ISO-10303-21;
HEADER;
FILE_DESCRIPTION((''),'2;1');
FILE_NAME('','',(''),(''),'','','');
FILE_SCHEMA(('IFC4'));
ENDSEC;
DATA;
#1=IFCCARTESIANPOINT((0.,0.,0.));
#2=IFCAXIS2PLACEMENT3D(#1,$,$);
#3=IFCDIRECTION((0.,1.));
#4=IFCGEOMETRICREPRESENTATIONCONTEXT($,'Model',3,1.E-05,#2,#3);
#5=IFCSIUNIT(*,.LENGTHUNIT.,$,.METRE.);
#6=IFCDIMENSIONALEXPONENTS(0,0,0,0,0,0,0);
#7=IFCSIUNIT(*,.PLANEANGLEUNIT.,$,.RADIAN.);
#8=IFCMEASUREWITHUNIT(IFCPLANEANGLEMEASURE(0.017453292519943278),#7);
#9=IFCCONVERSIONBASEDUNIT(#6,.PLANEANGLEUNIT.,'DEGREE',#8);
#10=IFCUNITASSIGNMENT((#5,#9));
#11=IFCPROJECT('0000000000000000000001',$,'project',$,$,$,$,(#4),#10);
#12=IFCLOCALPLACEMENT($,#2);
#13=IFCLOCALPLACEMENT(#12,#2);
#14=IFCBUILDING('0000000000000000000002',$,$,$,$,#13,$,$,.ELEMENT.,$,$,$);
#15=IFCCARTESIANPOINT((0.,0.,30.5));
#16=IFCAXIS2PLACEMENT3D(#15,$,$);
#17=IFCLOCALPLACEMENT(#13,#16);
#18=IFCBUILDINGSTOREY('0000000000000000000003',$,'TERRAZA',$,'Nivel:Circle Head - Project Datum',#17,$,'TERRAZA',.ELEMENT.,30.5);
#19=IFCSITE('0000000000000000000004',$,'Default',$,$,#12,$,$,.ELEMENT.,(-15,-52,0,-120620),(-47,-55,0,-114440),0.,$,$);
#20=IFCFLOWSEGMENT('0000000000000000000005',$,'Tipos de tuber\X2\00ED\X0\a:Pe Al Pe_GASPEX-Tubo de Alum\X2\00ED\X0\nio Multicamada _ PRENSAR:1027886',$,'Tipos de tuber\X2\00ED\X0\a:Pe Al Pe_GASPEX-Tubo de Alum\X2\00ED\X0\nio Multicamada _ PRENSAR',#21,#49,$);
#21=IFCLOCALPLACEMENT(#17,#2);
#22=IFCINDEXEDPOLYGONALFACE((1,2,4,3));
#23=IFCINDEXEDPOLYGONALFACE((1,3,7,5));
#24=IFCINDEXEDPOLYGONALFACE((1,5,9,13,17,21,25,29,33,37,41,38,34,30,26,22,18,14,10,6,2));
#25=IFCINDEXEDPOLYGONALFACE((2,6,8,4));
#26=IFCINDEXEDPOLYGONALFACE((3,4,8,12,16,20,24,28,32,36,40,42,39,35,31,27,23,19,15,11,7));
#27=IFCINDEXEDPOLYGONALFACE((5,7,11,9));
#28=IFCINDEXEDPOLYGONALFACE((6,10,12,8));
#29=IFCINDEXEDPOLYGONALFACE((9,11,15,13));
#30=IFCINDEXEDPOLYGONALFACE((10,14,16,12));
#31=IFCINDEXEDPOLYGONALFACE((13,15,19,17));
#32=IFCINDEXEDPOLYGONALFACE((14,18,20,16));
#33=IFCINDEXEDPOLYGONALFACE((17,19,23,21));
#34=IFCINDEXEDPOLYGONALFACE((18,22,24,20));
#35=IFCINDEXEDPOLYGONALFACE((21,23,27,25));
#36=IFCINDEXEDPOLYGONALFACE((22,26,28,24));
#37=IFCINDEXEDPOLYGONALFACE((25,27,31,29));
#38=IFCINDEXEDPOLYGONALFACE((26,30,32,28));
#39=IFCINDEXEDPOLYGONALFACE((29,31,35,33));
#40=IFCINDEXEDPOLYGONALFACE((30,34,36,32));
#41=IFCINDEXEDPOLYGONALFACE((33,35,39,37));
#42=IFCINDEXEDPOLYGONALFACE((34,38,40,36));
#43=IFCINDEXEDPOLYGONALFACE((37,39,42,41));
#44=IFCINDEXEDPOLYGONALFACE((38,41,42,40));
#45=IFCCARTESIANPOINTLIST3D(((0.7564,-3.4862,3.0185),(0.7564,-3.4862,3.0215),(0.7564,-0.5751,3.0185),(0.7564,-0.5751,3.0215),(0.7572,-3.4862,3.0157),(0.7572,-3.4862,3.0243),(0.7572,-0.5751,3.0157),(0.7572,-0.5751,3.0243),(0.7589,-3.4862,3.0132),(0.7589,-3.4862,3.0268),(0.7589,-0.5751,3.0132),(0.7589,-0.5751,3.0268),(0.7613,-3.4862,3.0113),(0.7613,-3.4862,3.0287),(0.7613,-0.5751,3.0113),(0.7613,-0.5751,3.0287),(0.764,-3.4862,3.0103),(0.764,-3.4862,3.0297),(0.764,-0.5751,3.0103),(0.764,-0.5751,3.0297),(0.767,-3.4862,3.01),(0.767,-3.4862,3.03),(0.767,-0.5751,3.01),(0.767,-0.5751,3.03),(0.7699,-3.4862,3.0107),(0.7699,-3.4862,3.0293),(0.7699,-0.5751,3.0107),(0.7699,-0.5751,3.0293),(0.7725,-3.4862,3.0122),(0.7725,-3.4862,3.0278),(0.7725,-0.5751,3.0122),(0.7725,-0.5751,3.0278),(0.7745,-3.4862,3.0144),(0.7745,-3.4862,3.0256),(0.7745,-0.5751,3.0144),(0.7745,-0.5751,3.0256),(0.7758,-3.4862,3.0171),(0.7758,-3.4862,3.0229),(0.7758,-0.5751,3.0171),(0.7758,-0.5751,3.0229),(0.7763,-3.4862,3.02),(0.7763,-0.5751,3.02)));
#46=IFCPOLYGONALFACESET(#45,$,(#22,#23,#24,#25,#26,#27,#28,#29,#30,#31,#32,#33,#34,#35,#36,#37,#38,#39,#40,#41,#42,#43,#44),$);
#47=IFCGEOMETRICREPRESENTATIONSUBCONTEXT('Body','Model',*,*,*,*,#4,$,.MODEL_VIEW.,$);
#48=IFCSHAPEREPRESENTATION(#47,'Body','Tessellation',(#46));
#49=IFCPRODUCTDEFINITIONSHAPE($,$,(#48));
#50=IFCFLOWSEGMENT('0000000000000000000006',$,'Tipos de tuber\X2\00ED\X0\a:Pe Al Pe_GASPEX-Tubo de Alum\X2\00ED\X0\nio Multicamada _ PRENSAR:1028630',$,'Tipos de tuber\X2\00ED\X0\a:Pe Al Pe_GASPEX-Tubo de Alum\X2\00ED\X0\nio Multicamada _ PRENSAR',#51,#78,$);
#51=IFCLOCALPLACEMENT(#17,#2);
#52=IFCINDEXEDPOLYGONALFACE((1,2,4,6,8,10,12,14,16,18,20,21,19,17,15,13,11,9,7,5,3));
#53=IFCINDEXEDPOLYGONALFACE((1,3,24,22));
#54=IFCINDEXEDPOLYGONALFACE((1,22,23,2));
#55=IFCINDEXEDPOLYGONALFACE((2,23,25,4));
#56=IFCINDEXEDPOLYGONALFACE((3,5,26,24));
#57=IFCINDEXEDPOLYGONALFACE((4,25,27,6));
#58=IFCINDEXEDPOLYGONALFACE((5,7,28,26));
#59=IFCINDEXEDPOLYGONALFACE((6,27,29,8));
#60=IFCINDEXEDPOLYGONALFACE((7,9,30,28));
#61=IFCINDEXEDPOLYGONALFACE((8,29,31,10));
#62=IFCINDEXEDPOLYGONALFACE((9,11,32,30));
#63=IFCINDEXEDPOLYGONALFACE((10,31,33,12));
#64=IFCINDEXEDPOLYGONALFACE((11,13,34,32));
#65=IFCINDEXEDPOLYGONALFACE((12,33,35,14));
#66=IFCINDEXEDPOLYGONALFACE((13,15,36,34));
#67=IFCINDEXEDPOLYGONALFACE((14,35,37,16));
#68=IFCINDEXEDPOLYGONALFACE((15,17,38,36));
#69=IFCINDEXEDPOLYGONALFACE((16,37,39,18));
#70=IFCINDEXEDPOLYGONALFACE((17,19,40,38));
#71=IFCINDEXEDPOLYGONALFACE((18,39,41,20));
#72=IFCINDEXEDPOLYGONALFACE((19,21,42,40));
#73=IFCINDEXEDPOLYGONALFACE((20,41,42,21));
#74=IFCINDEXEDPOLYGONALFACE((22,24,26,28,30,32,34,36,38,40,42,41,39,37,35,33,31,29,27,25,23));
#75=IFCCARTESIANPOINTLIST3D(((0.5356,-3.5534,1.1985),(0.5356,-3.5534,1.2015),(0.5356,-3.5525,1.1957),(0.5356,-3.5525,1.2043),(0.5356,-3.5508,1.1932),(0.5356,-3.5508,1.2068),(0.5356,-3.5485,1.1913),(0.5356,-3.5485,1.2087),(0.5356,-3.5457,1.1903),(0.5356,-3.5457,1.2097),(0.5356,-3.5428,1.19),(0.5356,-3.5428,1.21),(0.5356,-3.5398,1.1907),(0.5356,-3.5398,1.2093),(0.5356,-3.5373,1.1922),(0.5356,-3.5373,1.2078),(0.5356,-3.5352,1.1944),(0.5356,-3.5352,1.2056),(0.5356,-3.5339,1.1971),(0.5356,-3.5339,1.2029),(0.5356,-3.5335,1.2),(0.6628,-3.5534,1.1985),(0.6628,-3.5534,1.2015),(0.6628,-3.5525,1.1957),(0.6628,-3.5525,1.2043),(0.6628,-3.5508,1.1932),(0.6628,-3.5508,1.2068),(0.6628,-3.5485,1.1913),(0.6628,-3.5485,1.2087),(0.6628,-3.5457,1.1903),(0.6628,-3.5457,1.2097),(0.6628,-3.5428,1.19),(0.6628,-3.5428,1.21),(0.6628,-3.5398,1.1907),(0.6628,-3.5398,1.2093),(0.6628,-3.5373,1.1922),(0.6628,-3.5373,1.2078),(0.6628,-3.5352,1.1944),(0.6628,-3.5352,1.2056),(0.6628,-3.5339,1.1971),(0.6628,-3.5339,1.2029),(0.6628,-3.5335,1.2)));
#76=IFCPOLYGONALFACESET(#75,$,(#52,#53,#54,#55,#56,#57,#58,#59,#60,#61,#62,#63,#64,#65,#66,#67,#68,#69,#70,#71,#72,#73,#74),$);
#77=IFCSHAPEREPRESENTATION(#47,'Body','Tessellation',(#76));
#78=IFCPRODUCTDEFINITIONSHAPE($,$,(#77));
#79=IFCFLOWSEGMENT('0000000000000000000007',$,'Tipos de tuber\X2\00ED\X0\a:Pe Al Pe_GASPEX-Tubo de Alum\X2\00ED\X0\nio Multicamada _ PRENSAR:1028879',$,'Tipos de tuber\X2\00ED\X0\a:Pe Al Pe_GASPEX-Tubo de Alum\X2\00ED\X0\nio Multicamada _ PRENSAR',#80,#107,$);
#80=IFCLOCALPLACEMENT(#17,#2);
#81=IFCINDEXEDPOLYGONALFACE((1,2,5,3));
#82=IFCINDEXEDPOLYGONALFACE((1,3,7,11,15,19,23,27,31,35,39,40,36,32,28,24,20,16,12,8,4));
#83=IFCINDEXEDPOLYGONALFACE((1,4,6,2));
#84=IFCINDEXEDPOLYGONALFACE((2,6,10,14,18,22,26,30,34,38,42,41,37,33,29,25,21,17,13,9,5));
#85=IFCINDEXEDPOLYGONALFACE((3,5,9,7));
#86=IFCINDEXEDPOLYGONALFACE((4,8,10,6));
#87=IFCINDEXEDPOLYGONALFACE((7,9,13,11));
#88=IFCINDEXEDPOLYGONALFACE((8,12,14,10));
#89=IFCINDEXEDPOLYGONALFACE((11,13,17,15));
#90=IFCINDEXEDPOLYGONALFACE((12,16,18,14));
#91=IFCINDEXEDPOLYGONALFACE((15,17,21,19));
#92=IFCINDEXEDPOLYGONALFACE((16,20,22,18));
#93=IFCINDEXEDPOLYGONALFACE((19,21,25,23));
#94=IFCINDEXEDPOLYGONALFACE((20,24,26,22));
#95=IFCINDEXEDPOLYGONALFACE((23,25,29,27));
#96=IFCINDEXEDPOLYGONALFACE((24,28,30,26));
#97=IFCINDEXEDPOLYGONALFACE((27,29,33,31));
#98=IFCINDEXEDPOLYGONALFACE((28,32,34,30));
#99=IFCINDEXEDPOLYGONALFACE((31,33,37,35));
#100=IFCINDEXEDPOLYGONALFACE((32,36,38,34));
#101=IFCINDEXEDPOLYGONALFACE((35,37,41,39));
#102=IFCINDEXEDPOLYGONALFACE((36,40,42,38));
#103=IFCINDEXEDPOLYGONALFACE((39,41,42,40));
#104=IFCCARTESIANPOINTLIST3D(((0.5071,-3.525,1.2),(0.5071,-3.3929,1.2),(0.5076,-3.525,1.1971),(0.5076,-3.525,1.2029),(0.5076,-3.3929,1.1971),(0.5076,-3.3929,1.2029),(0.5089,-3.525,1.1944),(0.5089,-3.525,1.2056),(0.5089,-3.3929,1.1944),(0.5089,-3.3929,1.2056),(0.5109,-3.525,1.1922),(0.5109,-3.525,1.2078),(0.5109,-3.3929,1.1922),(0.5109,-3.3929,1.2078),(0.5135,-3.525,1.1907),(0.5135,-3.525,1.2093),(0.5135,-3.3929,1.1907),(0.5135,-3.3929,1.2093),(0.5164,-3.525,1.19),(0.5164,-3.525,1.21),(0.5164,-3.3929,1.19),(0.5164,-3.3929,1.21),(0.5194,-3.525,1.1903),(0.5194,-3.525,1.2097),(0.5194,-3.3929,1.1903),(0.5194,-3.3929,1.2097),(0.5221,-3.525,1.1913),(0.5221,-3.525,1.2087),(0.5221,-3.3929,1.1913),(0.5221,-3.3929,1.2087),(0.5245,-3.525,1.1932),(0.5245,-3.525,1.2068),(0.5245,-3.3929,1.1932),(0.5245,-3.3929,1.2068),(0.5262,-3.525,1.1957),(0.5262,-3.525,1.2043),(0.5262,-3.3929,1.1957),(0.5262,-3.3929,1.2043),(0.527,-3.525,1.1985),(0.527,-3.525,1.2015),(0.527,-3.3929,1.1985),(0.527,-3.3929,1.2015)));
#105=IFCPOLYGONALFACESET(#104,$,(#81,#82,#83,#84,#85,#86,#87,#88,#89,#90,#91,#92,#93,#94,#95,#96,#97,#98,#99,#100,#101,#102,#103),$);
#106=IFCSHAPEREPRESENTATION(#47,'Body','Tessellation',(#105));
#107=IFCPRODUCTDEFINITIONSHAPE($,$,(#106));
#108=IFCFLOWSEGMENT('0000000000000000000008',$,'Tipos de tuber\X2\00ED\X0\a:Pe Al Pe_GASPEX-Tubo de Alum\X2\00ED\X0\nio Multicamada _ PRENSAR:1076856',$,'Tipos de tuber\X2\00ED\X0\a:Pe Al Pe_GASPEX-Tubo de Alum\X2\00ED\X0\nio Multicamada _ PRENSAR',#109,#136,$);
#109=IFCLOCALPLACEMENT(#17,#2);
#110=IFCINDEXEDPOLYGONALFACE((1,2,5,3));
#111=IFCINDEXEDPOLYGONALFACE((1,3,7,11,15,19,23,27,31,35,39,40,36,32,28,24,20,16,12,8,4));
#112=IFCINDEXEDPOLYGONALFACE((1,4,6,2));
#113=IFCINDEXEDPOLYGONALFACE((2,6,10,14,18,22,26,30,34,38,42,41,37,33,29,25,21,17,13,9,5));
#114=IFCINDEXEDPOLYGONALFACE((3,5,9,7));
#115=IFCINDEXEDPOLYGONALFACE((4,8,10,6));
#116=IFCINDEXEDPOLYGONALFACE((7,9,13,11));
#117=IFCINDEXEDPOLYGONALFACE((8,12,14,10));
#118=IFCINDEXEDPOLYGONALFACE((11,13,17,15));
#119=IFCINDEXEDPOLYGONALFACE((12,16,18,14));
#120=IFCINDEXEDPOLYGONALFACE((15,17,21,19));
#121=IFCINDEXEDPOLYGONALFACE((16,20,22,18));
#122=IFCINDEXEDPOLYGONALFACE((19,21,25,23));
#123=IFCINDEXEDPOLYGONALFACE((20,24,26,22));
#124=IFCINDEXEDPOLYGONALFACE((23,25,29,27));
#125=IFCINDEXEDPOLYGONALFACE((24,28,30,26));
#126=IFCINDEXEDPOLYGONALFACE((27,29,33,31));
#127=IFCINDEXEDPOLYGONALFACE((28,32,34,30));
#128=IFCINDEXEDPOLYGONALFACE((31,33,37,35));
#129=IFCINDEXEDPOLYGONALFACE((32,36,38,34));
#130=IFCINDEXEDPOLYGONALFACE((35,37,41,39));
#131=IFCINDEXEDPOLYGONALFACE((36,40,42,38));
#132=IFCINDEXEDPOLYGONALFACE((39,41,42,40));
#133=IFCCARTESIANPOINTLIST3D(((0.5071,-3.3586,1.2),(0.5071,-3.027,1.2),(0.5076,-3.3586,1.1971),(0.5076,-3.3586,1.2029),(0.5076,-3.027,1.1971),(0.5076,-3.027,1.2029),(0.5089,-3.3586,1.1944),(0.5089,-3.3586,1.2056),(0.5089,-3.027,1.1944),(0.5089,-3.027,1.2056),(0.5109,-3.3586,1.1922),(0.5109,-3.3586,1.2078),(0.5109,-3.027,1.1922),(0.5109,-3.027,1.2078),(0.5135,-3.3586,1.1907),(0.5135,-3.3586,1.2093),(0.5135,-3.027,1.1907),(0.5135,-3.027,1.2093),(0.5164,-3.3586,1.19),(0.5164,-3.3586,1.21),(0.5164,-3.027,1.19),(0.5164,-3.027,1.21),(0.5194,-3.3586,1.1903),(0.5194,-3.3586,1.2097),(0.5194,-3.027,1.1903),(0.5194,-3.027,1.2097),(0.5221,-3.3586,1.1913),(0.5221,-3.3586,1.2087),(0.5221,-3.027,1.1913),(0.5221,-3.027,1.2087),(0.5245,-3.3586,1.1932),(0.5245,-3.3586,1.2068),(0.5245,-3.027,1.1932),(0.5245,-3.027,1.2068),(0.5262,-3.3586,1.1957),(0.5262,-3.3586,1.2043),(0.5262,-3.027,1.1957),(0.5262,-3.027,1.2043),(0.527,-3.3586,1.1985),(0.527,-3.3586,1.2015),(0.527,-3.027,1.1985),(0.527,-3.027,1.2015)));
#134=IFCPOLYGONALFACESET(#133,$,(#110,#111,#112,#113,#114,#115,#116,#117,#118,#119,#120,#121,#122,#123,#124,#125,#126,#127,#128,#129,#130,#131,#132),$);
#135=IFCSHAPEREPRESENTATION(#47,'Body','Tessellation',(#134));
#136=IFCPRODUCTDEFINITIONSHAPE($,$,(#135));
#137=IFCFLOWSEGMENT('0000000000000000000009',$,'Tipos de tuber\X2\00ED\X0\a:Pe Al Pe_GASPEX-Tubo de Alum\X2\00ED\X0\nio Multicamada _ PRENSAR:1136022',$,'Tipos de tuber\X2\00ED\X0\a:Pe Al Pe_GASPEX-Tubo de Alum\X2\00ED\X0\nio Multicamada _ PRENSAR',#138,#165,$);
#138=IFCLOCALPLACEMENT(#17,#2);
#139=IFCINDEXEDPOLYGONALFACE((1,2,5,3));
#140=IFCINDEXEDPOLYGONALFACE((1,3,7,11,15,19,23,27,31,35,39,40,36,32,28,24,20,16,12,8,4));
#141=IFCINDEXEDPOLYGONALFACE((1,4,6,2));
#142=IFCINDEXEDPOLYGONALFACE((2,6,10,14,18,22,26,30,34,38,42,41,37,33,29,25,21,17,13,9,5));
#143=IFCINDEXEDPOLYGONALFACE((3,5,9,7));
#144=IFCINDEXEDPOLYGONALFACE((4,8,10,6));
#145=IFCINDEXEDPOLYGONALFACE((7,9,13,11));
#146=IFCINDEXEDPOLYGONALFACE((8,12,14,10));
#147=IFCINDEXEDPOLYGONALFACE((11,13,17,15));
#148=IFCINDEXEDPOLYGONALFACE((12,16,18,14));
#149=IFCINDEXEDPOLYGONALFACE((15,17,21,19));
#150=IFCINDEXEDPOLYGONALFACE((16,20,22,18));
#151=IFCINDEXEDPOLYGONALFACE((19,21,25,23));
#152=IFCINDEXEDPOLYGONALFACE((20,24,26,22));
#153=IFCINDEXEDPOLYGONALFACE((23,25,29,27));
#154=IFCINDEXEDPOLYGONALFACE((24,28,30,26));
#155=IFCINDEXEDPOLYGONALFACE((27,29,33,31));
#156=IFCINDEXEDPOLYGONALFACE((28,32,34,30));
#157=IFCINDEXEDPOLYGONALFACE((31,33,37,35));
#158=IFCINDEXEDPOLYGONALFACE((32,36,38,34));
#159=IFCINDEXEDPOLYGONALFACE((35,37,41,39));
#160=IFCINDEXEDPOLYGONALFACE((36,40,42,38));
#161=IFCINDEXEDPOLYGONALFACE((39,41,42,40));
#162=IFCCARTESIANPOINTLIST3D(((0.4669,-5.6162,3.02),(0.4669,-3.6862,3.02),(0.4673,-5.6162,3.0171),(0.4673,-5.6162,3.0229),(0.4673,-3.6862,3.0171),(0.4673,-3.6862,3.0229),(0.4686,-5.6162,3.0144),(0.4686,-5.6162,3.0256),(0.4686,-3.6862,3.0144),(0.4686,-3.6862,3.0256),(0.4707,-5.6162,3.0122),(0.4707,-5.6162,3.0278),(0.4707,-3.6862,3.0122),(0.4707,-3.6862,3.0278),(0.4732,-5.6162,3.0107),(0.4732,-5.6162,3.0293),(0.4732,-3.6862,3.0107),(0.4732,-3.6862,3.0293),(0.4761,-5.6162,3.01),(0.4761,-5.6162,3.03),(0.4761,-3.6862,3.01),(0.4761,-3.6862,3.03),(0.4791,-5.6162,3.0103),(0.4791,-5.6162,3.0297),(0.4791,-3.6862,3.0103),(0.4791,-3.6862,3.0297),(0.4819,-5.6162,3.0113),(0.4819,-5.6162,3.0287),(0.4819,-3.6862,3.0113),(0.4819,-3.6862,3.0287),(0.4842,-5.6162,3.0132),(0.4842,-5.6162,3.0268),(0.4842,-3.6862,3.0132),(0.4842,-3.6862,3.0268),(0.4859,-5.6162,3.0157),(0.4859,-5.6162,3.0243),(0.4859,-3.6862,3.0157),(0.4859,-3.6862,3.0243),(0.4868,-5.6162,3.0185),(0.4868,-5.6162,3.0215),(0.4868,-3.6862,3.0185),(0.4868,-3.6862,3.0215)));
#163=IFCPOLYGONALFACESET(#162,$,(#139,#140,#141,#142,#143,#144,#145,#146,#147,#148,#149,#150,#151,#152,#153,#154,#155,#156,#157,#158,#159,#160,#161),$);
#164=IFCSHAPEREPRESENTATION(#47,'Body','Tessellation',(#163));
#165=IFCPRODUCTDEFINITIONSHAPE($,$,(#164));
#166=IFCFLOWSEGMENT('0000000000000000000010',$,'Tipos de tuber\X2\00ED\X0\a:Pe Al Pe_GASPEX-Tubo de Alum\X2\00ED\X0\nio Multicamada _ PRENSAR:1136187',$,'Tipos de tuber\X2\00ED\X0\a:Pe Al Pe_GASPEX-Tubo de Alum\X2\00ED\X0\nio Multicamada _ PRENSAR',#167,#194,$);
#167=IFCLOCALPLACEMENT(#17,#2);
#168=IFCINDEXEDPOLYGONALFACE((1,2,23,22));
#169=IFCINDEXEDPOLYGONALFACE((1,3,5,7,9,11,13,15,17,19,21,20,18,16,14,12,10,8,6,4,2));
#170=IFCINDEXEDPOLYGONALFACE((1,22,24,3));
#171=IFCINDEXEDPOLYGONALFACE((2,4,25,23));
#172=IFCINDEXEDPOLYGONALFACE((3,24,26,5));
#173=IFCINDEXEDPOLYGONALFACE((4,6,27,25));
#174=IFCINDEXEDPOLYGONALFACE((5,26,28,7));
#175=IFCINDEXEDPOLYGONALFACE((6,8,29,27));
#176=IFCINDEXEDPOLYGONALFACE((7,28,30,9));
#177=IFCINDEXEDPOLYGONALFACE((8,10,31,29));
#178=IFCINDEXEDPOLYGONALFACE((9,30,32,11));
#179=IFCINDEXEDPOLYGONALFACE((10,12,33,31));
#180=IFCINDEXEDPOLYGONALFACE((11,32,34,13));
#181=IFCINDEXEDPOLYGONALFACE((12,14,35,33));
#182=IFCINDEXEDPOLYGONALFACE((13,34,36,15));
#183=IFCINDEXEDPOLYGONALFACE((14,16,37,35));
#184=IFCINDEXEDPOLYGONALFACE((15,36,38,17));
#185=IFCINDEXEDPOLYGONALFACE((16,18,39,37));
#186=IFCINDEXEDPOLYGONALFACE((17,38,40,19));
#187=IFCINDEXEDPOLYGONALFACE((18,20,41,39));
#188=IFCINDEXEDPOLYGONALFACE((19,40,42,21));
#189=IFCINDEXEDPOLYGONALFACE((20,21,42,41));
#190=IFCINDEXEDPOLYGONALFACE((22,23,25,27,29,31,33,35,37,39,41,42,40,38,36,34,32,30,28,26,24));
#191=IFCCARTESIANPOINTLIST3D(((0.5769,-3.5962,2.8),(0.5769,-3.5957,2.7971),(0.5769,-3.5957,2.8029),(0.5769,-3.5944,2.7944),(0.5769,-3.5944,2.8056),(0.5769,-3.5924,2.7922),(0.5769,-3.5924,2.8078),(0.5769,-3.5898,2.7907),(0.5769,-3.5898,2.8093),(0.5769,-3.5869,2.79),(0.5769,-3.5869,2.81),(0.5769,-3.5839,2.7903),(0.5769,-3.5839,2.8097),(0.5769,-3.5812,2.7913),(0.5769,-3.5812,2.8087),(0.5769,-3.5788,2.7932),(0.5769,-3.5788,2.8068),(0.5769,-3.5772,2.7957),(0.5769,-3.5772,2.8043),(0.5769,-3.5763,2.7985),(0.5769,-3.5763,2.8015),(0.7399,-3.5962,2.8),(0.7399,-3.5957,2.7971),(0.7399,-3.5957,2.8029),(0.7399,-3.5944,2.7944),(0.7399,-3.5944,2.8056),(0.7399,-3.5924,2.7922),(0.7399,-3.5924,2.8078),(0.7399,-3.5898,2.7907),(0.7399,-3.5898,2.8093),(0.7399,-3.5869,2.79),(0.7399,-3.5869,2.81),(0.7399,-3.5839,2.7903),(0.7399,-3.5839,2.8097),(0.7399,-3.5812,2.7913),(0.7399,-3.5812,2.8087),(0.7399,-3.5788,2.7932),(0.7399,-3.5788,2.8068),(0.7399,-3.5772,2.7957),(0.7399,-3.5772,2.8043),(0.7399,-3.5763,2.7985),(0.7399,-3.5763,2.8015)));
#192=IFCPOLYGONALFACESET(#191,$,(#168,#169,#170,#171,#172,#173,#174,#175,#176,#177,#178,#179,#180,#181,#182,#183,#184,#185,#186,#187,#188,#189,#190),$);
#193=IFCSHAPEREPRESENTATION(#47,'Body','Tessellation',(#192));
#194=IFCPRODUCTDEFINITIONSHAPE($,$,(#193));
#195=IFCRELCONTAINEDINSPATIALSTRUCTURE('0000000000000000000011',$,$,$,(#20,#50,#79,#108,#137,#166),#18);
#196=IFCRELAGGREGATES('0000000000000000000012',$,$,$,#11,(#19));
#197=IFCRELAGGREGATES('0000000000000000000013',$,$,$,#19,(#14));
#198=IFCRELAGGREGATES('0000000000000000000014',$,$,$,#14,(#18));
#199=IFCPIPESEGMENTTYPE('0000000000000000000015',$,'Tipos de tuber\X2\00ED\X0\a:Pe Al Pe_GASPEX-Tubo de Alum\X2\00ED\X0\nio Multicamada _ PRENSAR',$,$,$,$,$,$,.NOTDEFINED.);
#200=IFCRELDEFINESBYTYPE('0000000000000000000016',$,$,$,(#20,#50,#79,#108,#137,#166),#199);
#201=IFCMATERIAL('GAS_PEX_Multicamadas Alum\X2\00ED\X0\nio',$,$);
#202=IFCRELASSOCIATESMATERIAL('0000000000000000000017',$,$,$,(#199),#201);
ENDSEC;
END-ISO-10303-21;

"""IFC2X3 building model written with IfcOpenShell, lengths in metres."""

from ifc_helpers import new_model, entity, si_unit, converted_unit, direction, frame, frame_2d, origin, origin_2d_with_axis, place, context, subcontext, project, spatial, circle, extrude, material, type_object, element, save


model = new_model("IFC2X3")

# Units and contexts
model_context = context("Model", 3, precision=1e-05, world=origin(), true_north=direction((0.0, 1.0)))
body_context = subcontext(model_context, "Body", "Model", "MODEL_VIEW")
ifc_project = project(units=[si_unit("LENGTHUNIT", "METRE"), converted_unit("PLANEANGLEUNIT", "DEGREE", entity("IfcPlaneAngleMeasure", 0.017453292519943278), si_unit("PLANEANGLEUNIT", "RADIAN"), dimensions=[0, 0, 0, 0, 0, 0, 0])], contexts=[model_context])

# Site, building, storey
site_placement = place(None, origin())
site = spatial("IfcSite", under=ifc_project, at=site_placement, Name="Default", CompositionType="ELEMENT", RefLatitude=(-15, -52, 0, -120620), RefLongitude=(-47, -55, 0, -114440), RefElevation=0.0)
building_placement = place(site_placement, origin())
building = spatial("IfcBuilding", under=site, at=building_placement, CompositionType="ELEMENT")
storey_placement = place(building_placement, frame((0.0, 0.0, 30.5)))
storey = spatial("IfcBuildingStorey", under=building, at=storey_placement, Name="TERRAZA", ObjectType="Nivel:Circle Head - Project Datum", LongName="TERRAZA", CompositionType="ELEMENT", Elevation=30.5)

# Flow segments
ifc_material = material(Name="GAS_PEX_Multicamadas Alumínio")
pipe_segment_type = type_object("IfcPipeSegmentType", Name="Tipos de tubería:Pe Al Pe_GASPEX-Tubo de Alumínio Multicamada _ PRENSAR", PredefinedType="NOTDEFINED", material=ifc_material)
flow_segment_1_placement = place(storey_placement, origin())
element("IfcFlowSegment", 1, at=flow_segment_1_placement, inside=storey, type_object=pipe_segment_type, Name="Tipos de tubería:Pe Al Pe_GASPEX-Tubo de Alumínio Multicamada _ PRENSAR:1027886", ObjectType="Tipos de tubería:Pe Al Pe_GASPEX-Tubo de Alumínio Multicamada _ PRENSAR", context=body_context, shape_type="SweptSolid", body=[
    extrude(circle(Radius=0.01, at=origin_2d_with_axis()), frame((0.7663, -3.4862, 3.02), z_axis=(0.0, 1.0, 0.0), x_axis=(1.0, 0.0, 0.0)), (0.0, 0.0, 1.0), 2.911),
])
flow_segment_2_placement = place(storey_placement, origin())
element("IfcFlowSegment", 2, at=flow_segment_2_placement, inside=storey, type_object=pipe_segment_type, Name="Tipos de tubería:Pe Al Pe_GASPEX-Tubo de Alumínio Multicamada _ PRENSAR:1028630", ObjectType="Tipos de tubería:Pe Al Pe_GASPEX-Tubo de Alumínio Multicamada _ PRENSAR", context=body_context, shape_type="SweptSolid", body=[
    extrude(circle(Radius=0.01, at=origin_2d_with_axis()), frame((0.5356, -3.5435, 1.2), z_axis=(1.0, 0.0, 0.0), x_axis=(0.0, 1.0, 0.0)), (0.0, 0.0, 1.0), 0.1271),
])
flow_segment_3_placement = place(storey_placement, origin())
element("IfcFlowSegment", 3, at=flow_segment_3_placement, inside=storey, type_object=pipe_segment_type, Name="Tipos de tubería:Pe Al Pe_GASPEX-Tubo de Alumínio Multicamada _ PRENSAR:1028879", ObjectType="Tipos de tubería:Pe Al Pe_GASPEX-Tubo de Alumínio Multicamada _ PRENSAR", context=body_context, shape_type="SweptSolid", body=[
    extrude(circle(Radius=0.01, at=frame_2d((0.0, 0.0), x_axis=(1.0, 0.0))), frame((0.5171, -3.525, 1.2), z_axis=(0.0, 1.0, 0.0), x_axis=(-1.0, 0.0, 0.0)), (0.0, 0.0, 1.0), 0.1321),
])
flow_segment_4_placement = place(storey_placement, origin())
element("IfcFlowSegment", 4, at=flow_segment_4_placement, inside=storey, type_object=pipe_segment_type, Name="Tipos de tubería:Pe Al Pe_GASPEX-Tubo de Alumínio Multicamada _ PRENSAR:1076856", ObjectType="Tipos de tubería:Pe Al Pe_GASPEX-Tubo de Alumínio Multicamada _ PRENSAR", context=body_context, shape_type="SweptSolid", body=[
    extrude(circle(Radius=0.01, at=frame_2d((0.0, 0.0), x_axis=(1.0, 0.0))), frame((0.5171, -3.3586, 1.2), z_axis=(0.0, 1.0, 0.0), x_axis=(-1.0, 0.0, 0.0)), (0.0, 0.0, 1.0), 0.3316),
])
flow_segment_5_placement = place(storey_placement, origin())
element("IfcFlowSegment", 5, at=flow_segment_5_placement, inside=storey, type_object=pipe_segment_type, Name="Tipos de tubería:Pe Al Pe_GASPEX-Tubo de Alumínio Multicamada _ PRENSAR:1136022", ObjectType="Tipos de tubería:Pe Al Pe_GASPEX-Tubo de Alumínio Multicamada _ PRENSAR", context=body_context, shape_type="SweptSolid", body=[
    extrude(circle(Radius=0.01, at=frame_2d((0.0, 0.0), x_axis=(1.0, 0.0))), frame((0.4769, -5.6162, 3.02), z_axis=(0.0, 1.0, 0.0), x_axis=(-1.0, 0.0, 0.0)), (0.0, 0.0, 1.0), 1.93),
])
flow_segment_6_placement = place(storey_placement, origin())
element("IfcFlowSegment", 6, at=flow_segment_6_placement, inside=storey, type_object=pipe_segment_type, Name="Tipos de tubería:Pe Al Pe_GASPEX-Tubo de Alumínio Multicamada _ PRENSAR:1136187", ObjectType="Tipos de tubería:Pe Al Pe_GASPEX-Tubo de Alumínio Multicamada _ PRENSAR", context=body_context, shape_type="SweptSolid", body=[
    extrude(circle(Radius=0.01, at=origin_2d_with_axis()), frame((0.5769, -3.5862, 2.8), z_axis=(1.0, 0.0, 0.0), x_axis=(0.0, -1.0, 0.0)), (0.0, 0.0, 1.0), 0.163),
])

save(model, "model.ifc")
